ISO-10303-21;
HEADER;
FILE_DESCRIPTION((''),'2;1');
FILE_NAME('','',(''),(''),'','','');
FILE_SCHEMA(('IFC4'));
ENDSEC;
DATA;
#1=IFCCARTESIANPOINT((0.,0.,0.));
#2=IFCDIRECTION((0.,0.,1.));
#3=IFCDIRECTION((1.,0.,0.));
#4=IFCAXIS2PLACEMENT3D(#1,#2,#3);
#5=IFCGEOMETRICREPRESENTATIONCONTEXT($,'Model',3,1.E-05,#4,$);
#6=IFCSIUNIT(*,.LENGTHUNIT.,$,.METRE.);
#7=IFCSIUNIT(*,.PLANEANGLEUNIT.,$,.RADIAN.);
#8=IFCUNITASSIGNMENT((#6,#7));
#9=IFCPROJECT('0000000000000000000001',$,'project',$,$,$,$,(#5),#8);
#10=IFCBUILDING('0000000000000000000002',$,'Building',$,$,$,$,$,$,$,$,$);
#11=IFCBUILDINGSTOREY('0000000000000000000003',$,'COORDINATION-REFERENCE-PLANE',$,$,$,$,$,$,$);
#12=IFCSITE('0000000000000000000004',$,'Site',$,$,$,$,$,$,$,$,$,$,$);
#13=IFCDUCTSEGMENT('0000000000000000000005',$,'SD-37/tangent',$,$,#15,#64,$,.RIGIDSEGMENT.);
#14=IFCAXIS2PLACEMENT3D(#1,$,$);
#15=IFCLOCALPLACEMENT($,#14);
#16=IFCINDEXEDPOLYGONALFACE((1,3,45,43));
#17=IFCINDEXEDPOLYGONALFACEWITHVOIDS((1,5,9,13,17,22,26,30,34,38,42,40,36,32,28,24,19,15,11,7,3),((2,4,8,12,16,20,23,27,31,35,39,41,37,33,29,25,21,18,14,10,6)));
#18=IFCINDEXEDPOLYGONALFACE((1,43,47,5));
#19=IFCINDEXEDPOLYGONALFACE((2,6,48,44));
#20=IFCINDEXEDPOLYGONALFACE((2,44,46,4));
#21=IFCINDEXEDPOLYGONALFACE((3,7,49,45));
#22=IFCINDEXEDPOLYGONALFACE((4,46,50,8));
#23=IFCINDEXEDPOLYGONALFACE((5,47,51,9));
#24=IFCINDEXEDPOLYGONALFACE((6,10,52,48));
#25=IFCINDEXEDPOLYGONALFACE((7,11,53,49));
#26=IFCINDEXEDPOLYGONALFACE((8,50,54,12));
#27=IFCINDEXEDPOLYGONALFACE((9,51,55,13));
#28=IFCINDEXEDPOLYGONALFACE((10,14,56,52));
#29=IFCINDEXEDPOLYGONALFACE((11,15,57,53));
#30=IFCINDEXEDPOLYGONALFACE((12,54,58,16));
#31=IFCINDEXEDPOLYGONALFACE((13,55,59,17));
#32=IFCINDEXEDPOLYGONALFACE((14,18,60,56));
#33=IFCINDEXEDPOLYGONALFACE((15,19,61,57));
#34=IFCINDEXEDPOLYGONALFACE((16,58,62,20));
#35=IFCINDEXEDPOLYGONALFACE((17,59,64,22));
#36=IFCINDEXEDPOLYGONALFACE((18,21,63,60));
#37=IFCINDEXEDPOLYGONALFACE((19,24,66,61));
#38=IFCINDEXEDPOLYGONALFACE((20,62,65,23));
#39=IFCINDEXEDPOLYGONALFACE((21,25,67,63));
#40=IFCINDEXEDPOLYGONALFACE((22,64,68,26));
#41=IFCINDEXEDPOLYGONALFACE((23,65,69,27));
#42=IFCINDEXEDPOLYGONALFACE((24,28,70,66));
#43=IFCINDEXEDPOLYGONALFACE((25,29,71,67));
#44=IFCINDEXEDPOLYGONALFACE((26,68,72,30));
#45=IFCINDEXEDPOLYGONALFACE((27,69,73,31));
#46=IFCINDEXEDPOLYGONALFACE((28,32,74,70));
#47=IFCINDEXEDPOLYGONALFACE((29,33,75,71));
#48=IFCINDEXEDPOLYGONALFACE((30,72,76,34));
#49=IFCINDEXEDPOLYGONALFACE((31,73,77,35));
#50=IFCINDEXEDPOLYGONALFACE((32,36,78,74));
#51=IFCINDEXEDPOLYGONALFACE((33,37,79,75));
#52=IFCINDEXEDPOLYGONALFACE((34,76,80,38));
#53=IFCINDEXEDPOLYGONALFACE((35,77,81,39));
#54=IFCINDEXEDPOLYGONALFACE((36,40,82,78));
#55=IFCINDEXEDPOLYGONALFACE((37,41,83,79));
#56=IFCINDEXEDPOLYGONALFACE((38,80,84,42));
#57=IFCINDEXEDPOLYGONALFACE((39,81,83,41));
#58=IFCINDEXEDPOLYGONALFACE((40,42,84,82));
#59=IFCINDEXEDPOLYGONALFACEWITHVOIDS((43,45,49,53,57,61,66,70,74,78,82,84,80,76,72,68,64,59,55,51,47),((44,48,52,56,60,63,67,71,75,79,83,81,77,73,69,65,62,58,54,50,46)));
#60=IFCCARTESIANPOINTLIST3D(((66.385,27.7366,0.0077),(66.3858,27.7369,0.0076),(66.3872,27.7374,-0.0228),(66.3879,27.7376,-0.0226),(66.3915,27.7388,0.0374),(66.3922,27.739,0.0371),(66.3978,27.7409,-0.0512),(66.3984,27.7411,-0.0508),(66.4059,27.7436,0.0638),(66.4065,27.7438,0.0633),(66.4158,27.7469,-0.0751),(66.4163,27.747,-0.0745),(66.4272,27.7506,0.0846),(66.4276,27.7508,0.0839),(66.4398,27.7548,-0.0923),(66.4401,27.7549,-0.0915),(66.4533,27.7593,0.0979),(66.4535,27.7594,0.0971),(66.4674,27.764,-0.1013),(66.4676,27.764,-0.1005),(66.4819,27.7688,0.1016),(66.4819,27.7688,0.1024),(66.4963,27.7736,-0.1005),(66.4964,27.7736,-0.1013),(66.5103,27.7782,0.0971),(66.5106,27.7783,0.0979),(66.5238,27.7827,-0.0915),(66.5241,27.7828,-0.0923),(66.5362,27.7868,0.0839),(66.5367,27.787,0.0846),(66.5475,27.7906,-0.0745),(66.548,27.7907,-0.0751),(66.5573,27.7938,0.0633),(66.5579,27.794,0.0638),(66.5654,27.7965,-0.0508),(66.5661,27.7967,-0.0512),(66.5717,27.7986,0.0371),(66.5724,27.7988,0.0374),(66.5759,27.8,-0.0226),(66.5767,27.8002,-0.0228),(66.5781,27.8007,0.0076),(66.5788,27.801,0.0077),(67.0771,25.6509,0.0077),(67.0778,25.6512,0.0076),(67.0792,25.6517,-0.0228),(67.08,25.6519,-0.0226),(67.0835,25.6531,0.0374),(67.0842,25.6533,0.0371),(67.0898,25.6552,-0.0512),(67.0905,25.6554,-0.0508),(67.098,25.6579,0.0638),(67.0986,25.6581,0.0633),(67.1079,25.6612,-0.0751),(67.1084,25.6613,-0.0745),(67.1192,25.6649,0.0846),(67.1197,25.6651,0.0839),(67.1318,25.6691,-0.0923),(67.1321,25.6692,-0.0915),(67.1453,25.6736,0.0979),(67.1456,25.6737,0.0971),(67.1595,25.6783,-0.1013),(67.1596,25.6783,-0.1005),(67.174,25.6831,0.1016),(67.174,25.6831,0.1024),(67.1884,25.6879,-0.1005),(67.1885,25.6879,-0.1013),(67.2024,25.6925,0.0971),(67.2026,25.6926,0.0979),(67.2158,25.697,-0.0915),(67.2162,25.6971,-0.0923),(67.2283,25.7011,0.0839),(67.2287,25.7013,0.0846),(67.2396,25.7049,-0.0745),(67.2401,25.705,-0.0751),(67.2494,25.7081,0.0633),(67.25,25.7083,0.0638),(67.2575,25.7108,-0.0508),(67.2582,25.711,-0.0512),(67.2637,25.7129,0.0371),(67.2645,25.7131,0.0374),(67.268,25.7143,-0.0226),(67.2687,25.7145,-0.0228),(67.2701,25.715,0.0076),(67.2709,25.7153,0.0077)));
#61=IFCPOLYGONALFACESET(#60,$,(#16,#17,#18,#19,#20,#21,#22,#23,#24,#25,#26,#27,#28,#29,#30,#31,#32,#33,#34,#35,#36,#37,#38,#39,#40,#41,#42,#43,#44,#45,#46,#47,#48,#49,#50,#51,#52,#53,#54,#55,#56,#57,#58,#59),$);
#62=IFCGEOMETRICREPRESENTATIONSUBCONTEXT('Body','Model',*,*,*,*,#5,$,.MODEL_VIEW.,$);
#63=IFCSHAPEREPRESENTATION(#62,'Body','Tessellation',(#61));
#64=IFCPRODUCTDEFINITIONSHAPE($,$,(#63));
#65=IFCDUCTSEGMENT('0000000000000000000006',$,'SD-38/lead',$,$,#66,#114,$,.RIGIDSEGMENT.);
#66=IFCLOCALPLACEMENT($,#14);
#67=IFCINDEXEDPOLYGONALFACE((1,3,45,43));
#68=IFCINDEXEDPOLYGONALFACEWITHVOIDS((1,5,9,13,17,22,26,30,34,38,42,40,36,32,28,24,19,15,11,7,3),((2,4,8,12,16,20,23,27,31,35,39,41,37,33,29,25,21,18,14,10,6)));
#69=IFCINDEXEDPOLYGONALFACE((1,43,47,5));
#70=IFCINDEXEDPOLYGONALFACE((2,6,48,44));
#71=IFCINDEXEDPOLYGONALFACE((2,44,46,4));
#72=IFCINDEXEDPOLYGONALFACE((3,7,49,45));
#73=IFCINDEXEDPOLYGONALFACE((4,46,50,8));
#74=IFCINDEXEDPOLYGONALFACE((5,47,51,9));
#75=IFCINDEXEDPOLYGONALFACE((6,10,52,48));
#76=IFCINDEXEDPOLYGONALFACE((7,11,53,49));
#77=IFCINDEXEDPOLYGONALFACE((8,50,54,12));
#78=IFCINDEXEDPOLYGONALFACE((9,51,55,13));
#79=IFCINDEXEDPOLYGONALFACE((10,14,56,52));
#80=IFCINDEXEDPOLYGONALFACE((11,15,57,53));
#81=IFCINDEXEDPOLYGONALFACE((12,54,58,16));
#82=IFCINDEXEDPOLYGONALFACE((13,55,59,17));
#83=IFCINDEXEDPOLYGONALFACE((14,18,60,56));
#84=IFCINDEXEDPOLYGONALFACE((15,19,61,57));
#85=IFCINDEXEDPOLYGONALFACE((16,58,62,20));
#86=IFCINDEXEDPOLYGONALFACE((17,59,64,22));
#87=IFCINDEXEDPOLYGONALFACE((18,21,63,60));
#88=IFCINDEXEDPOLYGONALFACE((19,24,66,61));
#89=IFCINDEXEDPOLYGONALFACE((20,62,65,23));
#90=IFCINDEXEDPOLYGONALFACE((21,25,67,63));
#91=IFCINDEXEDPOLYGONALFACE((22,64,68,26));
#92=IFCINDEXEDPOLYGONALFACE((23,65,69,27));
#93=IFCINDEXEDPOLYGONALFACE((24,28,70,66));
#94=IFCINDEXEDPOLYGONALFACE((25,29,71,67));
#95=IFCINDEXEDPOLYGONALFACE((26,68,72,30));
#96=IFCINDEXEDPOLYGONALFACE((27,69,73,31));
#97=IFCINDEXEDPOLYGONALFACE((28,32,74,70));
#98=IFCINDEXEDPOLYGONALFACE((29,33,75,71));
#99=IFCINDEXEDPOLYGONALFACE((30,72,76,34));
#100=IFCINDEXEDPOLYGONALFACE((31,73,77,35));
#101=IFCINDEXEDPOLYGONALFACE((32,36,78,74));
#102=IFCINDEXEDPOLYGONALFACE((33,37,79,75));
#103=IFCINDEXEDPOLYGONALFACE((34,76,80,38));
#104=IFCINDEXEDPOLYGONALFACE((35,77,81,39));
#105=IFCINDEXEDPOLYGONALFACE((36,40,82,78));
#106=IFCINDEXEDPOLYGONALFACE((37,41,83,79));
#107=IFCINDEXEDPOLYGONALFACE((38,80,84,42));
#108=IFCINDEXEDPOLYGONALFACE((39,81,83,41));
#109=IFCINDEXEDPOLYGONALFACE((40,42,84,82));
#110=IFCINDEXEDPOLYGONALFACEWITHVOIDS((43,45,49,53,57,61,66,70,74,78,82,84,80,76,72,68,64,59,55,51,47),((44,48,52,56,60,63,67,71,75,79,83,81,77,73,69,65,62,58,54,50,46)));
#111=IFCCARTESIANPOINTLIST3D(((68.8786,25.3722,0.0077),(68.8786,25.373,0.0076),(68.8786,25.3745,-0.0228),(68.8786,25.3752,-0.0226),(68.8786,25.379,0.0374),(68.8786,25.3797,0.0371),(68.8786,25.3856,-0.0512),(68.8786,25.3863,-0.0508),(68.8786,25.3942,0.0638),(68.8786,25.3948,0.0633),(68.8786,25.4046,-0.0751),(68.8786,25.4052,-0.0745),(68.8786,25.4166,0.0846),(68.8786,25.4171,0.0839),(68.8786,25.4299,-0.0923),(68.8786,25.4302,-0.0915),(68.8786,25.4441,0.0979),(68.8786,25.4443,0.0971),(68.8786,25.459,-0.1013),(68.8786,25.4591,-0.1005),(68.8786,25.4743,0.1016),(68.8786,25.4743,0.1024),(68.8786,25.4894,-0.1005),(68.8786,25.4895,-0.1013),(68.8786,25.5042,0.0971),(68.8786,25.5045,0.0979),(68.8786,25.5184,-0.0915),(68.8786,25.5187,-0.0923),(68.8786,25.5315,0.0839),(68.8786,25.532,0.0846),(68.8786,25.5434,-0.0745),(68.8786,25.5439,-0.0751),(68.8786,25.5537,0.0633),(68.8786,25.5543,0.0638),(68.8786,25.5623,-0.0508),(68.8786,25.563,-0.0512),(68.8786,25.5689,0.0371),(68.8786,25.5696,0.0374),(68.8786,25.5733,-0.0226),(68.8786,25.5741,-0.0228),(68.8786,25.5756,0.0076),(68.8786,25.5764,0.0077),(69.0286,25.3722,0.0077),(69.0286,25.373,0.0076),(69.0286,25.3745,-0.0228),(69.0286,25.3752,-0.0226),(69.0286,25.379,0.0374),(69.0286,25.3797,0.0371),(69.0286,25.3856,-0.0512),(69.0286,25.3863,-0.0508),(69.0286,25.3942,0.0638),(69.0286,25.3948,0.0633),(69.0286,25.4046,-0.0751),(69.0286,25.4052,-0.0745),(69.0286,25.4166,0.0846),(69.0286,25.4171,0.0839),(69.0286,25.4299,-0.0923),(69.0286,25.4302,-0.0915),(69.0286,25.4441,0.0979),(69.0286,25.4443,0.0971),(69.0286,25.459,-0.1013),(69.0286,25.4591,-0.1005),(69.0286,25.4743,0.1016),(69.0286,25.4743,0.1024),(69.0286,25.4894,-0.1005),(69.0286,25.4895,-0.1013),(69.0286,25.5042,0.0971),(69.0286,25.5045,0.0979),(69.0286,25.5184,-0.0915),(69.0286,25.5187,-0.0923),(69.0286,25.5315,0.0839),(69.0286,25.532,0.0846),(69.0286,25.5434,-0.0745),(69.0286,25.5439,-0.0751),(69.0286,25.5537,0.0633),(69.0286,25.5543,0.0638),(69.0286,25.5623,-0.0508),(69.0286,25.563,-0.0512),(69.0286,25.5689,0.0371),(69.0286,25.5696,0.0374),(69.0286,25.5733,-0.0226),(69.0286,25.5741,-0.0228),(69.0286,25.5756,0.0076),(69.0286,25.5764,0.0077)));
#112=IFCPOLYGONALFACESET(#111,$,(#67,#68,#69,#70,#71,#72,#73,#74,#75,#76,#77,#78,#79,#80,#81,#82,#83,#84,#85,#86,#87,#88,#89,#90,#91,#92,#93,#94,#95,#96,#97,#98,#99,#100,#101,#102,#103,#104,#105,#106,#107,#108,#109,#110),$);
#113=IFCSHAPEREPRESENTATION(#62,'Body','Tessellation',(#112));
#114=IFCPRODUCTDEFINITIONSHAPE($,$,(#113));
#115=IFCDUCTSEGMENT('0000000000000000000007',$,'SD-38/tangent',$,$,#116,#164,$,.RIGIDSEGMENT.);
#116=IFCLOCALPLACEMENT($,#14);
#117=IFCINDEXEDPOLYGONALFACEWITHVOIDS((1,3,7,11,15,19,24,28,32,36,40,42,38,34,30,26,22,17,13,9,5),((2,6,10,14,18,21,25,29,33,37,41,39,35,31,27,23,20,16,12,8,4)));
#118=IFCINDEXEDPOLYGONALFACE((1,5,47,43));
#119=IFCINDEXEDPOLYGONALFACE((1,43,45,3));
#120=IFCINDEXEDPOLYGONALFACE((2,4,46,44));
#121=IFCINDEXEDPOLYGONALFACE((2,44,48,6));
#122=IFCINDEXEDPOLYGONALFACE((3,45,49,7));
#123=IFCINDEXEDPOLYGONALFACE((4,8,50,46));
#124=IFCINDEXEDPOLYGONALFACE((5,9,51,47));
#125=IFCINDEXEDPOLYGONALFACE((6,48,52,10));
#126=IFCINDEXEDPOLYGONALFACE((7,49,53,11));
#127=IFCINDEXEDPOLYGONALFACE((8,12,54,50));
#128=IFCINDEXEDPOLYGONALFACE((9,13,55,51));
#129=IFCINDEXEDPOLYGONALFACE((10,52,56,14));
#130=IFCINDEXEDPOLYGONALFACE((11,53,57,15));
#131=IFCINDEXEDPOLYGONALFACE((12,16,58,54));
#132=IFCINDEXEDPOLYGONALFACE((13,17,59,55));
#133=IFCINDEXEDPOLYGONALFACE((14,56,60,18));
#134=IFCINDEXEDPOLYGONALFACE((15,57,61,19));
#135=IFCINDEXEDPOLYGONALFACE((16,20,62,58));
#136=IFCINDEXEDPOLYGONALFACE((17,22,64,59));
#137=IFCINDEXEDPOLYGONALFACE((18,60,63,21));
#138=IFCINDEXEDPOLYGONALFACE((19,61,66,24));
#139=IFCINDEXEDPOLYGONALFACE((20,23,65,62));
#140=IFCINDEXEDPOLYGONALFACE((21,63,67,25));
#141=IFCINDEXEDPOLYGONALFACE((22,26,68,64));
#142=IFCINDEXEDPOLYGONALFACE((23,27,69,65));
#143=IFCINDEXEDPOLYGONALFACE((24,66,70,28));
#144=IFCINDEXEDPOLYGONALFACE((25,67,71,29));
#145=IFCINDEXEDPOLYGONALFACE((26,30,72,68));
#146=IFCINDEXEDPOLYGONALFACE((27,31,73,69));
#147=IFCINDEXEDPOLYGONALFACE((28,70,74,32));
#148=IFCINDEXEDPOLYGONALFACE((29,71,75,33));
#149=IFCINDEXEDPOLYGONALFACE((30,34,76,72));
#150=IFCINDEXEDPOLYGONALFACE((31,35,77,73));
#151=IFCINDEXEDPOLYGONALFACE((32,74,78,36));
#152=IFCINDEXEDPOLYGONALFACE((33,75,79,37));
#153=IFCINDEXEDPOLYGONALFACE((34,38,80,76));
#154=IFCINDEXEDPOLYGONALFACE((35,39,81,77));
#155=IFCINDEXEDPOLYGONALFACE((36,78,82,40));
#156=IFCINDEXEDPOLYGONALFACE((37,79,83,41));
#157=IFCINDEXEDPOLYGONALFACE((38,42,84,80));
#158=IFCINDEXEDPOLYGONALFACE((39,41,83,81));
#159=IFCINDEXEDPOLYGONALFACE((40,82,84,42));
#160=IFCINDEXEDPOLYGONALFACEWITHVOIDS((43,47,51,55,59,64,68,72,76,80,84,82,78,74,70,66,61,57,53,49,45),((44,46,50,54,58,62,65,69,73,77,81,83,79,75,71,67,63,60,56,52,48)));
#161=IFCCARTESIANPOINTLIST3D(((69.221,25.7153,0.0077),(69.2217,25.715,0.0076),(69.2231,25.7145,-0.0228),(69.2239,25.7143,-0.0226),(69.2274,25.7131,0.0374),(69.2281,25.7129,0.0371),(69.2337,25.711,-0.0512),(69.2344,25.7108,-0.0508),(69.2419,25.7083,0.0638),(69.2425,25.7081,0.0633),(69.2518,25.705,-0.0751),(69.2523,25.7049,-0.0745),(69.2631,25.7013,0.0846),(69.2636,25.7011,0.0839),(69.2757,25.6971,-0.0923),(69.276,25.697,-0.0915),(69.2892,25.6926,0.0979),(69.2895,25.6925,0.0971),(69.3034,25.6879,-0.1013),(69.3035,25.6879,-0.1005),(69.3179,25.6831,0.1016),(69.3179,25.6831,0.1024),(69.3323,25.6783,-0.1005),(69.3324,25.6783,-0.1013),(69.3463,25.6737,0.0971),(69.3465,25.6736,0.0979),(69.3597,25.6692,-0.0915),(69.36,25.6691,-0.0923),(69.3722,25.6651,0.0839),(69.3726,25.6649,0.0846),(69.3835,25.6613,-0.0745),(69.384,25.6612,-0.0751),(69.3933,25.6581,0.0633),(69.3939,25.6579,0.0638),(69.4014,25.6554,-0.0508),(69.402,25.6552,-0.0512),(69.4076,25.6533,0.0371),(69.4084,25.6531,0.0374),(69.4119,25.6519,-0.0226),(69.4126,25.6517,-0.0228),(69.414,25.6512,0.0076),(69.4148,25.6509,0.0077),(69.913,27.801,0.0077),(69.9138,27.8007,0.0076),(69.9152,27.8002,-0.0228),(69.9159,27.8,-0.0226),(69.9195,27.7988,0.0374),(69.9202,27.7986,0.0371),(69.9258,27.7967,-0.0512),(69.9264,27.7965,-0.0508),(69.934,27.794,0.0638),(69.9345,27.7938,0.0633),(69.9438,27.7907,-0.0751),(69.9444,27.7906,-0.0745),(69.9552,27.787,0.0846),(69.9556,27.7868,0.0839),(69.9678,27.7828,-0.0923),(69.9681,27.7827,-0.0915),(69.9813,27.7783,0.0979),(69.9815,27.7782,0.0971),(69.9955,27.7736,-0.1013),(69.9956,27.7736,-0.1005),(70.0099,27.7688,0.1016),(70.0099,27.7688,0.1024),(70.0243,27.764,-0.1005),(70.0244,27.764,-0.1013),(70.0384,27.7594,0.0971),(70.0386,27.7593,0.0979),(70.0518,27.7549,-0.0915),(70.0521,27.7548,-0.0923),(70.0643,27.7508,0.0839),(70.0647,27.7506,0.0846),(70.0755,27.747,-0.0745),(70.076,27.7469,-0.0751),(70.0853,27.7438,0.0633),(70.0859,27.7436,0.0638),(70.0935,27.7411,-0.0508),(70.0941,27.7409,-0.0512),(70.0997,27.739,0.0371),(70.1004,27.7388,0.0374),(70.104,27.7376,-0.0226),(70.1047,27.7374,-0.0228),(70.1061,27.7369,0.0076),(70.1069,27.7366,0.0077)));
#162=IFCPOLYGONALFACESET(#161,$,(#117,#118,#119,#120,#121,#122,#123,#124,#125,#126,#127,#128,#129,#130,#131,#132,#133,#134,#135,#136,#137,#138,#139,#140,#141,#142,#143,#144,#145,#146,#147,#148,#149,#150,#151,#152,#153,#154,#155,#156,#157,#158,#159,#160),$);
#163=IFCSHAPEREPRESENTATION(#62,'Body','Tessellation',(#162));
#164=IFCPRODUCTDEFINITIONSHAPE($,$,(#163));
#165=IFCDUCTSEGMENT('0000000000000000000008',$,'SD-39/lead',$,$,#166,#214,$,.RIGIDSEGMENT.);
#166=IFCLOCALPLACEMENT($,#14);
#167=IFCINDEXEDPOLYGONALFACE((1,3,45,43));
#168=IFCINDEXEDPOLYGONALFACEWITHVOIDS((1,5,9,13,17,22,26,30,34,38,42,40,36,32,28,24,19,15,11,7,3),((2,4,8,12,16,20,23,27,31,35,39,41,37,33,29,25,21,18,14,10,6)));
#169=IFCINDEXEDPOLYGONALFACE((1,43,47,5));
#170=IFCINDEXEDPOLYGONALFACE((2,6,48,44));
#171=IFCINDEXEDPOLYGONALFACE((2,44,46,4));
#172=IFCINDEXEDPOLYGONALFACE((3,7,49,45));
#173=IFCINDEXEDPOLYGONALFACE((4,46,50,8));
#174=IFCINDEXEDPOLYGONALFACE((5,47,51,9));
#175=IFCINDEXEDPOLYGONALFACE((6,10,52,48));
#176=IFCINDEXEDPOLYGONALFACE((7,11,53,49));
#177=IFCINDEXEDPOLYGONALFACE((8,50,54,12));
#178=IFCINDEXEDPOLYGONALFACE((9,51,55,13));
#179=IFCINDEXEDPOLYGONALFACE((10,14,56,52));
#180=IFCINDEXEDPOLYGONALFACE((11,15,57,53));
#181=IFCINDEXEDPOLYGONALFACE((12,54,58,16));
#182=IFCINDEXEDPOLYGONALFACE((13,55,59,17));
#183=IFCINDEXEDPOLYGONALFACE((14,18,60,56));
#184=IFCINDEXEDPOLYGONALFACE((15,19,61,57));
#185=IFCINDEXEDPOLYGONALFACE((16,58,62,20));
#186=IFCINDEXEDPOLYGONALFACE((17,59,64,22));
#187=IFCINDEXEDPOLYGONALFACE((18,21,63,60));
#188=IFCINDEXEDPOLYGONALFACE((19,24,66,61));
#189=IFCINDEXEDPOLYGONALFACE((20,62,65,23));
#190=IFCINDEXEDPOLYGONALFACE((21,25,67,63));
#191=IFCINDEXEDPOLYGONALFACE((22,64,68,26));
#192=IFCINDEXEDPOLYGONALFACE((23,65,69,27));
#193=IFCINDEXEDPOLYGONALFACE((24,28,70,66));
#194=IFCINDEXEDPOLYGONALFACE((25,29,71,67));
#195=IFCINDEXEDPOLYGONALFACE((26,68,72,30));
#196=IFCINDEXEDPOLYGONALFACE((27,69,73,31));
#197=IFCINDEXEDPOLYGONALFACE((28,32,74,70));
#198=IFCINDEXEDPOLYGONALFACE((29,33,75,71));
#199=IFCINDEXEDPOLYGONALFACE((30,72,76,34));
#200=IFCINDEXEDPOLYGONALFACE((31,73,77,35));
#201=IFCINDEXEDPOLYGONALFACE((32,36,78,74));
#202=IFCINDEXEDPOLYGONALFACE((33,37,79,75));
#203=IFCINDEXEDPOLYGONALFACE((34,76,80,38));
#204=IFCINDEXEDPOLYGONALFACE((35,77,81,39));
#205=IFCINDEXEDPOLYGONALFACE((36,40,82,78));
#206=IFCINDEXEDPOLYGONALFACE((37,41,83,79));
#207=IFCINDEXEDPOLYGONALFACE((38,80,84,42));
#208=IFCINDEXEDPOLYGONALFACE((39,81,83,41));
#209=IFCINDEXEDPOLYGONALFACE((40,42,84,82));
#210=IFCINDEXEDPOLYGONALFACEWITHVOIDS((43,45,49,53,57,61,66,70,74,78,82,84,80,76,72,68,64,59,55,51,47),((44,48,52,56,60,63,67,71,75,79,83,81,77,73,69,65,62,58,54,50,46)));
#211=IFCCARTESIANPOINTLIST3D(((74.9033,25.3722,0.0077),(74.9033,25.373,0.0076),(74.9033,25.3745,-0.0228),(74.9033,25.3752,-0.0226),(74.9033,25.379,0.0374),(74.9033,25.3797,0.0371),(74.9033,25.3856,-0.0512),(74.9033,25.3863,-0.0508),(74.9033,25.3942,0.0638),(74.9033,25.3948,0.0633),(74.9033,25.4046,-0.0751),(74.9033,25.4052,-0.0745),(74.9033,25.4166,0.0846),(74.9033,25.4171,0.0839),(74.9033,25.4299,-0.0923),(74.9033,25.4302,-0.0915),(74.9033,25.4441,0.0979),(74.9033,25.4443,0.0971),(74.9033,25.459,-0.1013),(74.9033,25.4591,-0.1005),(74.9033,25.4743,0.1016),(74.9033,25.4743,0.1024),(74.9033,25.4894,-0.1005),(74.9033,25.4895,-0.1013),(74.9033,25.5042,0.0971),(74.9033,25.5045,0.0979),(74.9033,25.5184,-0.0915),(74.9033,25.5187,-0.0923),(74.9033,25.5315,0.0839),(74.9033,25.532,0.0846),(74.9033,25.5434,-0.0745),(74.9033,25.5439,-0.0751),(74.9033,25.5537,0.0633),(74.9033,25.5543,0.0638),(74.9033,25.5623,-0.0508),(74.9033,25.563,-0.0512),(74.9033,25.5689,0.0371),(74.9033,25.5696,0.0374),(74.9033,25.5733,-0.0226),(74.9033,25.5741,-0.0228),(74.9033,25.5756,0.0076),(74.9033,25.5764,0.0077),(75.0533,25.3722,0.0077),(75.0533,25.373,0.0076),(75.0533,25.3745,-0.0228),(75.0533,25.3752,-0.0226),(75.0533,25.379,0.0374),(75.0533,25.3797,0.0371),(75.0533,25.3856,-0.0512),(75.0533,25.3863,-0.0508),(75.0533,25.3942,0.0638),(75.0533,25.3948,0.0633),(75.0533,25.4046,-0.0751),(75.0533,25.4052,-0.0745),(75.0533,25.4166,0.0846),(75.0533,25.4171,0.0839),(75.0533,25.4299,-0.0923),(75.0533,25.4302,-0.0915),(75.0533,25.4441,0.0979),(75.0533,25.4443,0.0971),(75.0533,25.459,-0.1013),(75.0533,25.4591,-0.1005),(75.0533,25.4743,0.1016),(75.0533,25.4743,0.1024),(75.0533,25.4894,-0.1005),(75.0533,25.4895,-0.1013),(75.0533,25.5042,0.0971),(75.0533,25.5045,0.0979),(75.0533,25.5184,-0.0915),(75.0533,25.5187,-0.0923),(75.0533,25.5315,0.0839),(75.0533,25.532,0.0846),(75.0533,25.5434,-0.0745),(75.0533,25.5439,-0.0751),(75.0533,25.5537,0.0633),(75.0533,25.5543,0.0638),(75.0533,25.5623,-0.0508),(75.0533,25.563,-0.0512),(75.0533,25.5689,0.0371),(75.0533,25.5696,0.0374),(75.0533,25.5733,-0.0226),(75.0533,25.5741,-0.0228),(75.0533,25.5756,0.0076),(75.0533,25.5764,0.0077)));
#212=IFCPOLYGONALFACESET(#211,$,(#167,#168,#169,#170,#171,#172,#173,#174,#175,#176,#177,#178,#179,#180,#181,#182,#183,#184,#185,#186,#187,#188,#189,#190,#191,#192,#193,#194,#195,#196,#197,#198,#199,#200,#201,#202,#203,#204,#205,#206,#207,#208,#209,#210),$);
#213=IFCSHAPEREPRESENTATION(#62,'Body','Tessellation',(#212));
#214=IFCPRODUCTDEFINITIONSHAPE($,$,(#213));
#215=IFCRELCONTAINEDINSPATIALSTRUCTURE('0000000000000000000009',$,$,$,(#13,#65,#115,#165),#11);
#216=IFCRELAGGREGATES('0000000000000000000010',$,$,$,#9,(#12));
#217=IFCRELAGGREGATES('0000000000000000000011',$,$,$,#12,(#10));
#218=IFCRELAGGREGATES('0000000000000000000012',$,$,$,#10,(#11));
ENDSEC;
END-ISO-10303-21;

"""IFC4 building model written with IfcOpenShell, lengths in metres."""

from ifc_helpers import new_model, si_unit, frame, origin_with_axes, place, context, subcontext, project, spatial, hollow_circle, extrude, element, save


model = new_model("IFC4")

# Units and contexts
model_context = context("Model", 3, precision=1e-05, world=origin_with_axes())
body_context_1 = subcontext(model_context, "Body", "Model", "MODEL_VIEW")
ifc_project = project(units=[si_unit("LENGTHUNIT", "METRE"), si_unit("PLANEANGLEUNIT", "RADIAN")], contexts=[model_context])

# Site, building, storey
site = spatial("IfcSite", under=ifc_project, Name="Site")
building = spatial("IfcBuilding", under=site, Name="Building")
storey = spatial("IfcBuildingStorey", under=building, Name="COORDINATION-REFERENCE-PLANE")

# Duct segment
duct_segment_1_placement = place(None, frame((67.174, 25.6831, 0.0), z_axis=(-0.314929, 0.949115, 0.0), x_axis=(0.0, 0.0, 1.0)))
element("IfcDuctSegment", 1, at=duct_segment_1_placement, inside=storey, Name="SD-37/tangent", PredefinedType="RIGIDSEGMENT", context=body_context_1, shape_type="SweptSolid", body=[
    extrude(hollow_circle(Radius=0.1024, WallThickness=0.0008), origin_with_axes(), (0.0, 0.0, 1.0), 2.1975),
])

# Duct segment
duct_segment_2_placement = place(None, frame((68.8786, 25.4743, 0.0), z_axis=(1.0, 0.0, 0.0), x_axis=(0.0, 0.0, 1.0)))
element("IfcDuctSegment", 2, at=duct_segment_2_placement, inside=storey, Name="SD-38/lead", PredefinedType="RIGIDSEGMENT", context=body_context_1, shape_type="SweptSolid", body=[
    extrude(hollow_circle(Radius=0.1024, WallThickness=0.0008), origin_with_axes(), (0.0, 0.0, 1.0), 0.15),
])

# Duct segment
duct_segment_3_placement = place(None, frame((69.3179, 25.6831, 0.0), z_axis=(0.314929, 0.949115, 0.0), x_axis=(0.0, 0.0, 1.0)))
element("IfcDuctSegment", 3, at=duct_segment_3_placement, inside=storey, Name="SD-38/tangent", PredefinedType="RIGIDSEGMENT", context=body_context_1, shape_type="SweptSolid", body=[
    extrude(hollow_circle(Radius=0.1024, WallThickness=0.0008), origin_with_axes(), (0.0, 0.0, 1.0), 2.1975),
])

# Duct segment
duct_segment_4_placement = place(None, frame((75.0533, 25.4743, 0.0), z_axis=(-1.0, 0.0, 0.0), x_axis=(0.0, 0.0, 1.0)))
element("IfcDuctSegment", 4, at=duct_segment_4_placement, inside=storey, Name="SD-39/lead", PredefinedType="RIGIDSEGMENT", context=body_context_1, shape_type="SweptSolid", body=[
    extrude(hollow_circle(Radius=0.1024, WallThickness=0.0008), origin_with_axes(), (0.0, 0.0, 1.0), 0.15),
])

save(model, "model.ifc")
